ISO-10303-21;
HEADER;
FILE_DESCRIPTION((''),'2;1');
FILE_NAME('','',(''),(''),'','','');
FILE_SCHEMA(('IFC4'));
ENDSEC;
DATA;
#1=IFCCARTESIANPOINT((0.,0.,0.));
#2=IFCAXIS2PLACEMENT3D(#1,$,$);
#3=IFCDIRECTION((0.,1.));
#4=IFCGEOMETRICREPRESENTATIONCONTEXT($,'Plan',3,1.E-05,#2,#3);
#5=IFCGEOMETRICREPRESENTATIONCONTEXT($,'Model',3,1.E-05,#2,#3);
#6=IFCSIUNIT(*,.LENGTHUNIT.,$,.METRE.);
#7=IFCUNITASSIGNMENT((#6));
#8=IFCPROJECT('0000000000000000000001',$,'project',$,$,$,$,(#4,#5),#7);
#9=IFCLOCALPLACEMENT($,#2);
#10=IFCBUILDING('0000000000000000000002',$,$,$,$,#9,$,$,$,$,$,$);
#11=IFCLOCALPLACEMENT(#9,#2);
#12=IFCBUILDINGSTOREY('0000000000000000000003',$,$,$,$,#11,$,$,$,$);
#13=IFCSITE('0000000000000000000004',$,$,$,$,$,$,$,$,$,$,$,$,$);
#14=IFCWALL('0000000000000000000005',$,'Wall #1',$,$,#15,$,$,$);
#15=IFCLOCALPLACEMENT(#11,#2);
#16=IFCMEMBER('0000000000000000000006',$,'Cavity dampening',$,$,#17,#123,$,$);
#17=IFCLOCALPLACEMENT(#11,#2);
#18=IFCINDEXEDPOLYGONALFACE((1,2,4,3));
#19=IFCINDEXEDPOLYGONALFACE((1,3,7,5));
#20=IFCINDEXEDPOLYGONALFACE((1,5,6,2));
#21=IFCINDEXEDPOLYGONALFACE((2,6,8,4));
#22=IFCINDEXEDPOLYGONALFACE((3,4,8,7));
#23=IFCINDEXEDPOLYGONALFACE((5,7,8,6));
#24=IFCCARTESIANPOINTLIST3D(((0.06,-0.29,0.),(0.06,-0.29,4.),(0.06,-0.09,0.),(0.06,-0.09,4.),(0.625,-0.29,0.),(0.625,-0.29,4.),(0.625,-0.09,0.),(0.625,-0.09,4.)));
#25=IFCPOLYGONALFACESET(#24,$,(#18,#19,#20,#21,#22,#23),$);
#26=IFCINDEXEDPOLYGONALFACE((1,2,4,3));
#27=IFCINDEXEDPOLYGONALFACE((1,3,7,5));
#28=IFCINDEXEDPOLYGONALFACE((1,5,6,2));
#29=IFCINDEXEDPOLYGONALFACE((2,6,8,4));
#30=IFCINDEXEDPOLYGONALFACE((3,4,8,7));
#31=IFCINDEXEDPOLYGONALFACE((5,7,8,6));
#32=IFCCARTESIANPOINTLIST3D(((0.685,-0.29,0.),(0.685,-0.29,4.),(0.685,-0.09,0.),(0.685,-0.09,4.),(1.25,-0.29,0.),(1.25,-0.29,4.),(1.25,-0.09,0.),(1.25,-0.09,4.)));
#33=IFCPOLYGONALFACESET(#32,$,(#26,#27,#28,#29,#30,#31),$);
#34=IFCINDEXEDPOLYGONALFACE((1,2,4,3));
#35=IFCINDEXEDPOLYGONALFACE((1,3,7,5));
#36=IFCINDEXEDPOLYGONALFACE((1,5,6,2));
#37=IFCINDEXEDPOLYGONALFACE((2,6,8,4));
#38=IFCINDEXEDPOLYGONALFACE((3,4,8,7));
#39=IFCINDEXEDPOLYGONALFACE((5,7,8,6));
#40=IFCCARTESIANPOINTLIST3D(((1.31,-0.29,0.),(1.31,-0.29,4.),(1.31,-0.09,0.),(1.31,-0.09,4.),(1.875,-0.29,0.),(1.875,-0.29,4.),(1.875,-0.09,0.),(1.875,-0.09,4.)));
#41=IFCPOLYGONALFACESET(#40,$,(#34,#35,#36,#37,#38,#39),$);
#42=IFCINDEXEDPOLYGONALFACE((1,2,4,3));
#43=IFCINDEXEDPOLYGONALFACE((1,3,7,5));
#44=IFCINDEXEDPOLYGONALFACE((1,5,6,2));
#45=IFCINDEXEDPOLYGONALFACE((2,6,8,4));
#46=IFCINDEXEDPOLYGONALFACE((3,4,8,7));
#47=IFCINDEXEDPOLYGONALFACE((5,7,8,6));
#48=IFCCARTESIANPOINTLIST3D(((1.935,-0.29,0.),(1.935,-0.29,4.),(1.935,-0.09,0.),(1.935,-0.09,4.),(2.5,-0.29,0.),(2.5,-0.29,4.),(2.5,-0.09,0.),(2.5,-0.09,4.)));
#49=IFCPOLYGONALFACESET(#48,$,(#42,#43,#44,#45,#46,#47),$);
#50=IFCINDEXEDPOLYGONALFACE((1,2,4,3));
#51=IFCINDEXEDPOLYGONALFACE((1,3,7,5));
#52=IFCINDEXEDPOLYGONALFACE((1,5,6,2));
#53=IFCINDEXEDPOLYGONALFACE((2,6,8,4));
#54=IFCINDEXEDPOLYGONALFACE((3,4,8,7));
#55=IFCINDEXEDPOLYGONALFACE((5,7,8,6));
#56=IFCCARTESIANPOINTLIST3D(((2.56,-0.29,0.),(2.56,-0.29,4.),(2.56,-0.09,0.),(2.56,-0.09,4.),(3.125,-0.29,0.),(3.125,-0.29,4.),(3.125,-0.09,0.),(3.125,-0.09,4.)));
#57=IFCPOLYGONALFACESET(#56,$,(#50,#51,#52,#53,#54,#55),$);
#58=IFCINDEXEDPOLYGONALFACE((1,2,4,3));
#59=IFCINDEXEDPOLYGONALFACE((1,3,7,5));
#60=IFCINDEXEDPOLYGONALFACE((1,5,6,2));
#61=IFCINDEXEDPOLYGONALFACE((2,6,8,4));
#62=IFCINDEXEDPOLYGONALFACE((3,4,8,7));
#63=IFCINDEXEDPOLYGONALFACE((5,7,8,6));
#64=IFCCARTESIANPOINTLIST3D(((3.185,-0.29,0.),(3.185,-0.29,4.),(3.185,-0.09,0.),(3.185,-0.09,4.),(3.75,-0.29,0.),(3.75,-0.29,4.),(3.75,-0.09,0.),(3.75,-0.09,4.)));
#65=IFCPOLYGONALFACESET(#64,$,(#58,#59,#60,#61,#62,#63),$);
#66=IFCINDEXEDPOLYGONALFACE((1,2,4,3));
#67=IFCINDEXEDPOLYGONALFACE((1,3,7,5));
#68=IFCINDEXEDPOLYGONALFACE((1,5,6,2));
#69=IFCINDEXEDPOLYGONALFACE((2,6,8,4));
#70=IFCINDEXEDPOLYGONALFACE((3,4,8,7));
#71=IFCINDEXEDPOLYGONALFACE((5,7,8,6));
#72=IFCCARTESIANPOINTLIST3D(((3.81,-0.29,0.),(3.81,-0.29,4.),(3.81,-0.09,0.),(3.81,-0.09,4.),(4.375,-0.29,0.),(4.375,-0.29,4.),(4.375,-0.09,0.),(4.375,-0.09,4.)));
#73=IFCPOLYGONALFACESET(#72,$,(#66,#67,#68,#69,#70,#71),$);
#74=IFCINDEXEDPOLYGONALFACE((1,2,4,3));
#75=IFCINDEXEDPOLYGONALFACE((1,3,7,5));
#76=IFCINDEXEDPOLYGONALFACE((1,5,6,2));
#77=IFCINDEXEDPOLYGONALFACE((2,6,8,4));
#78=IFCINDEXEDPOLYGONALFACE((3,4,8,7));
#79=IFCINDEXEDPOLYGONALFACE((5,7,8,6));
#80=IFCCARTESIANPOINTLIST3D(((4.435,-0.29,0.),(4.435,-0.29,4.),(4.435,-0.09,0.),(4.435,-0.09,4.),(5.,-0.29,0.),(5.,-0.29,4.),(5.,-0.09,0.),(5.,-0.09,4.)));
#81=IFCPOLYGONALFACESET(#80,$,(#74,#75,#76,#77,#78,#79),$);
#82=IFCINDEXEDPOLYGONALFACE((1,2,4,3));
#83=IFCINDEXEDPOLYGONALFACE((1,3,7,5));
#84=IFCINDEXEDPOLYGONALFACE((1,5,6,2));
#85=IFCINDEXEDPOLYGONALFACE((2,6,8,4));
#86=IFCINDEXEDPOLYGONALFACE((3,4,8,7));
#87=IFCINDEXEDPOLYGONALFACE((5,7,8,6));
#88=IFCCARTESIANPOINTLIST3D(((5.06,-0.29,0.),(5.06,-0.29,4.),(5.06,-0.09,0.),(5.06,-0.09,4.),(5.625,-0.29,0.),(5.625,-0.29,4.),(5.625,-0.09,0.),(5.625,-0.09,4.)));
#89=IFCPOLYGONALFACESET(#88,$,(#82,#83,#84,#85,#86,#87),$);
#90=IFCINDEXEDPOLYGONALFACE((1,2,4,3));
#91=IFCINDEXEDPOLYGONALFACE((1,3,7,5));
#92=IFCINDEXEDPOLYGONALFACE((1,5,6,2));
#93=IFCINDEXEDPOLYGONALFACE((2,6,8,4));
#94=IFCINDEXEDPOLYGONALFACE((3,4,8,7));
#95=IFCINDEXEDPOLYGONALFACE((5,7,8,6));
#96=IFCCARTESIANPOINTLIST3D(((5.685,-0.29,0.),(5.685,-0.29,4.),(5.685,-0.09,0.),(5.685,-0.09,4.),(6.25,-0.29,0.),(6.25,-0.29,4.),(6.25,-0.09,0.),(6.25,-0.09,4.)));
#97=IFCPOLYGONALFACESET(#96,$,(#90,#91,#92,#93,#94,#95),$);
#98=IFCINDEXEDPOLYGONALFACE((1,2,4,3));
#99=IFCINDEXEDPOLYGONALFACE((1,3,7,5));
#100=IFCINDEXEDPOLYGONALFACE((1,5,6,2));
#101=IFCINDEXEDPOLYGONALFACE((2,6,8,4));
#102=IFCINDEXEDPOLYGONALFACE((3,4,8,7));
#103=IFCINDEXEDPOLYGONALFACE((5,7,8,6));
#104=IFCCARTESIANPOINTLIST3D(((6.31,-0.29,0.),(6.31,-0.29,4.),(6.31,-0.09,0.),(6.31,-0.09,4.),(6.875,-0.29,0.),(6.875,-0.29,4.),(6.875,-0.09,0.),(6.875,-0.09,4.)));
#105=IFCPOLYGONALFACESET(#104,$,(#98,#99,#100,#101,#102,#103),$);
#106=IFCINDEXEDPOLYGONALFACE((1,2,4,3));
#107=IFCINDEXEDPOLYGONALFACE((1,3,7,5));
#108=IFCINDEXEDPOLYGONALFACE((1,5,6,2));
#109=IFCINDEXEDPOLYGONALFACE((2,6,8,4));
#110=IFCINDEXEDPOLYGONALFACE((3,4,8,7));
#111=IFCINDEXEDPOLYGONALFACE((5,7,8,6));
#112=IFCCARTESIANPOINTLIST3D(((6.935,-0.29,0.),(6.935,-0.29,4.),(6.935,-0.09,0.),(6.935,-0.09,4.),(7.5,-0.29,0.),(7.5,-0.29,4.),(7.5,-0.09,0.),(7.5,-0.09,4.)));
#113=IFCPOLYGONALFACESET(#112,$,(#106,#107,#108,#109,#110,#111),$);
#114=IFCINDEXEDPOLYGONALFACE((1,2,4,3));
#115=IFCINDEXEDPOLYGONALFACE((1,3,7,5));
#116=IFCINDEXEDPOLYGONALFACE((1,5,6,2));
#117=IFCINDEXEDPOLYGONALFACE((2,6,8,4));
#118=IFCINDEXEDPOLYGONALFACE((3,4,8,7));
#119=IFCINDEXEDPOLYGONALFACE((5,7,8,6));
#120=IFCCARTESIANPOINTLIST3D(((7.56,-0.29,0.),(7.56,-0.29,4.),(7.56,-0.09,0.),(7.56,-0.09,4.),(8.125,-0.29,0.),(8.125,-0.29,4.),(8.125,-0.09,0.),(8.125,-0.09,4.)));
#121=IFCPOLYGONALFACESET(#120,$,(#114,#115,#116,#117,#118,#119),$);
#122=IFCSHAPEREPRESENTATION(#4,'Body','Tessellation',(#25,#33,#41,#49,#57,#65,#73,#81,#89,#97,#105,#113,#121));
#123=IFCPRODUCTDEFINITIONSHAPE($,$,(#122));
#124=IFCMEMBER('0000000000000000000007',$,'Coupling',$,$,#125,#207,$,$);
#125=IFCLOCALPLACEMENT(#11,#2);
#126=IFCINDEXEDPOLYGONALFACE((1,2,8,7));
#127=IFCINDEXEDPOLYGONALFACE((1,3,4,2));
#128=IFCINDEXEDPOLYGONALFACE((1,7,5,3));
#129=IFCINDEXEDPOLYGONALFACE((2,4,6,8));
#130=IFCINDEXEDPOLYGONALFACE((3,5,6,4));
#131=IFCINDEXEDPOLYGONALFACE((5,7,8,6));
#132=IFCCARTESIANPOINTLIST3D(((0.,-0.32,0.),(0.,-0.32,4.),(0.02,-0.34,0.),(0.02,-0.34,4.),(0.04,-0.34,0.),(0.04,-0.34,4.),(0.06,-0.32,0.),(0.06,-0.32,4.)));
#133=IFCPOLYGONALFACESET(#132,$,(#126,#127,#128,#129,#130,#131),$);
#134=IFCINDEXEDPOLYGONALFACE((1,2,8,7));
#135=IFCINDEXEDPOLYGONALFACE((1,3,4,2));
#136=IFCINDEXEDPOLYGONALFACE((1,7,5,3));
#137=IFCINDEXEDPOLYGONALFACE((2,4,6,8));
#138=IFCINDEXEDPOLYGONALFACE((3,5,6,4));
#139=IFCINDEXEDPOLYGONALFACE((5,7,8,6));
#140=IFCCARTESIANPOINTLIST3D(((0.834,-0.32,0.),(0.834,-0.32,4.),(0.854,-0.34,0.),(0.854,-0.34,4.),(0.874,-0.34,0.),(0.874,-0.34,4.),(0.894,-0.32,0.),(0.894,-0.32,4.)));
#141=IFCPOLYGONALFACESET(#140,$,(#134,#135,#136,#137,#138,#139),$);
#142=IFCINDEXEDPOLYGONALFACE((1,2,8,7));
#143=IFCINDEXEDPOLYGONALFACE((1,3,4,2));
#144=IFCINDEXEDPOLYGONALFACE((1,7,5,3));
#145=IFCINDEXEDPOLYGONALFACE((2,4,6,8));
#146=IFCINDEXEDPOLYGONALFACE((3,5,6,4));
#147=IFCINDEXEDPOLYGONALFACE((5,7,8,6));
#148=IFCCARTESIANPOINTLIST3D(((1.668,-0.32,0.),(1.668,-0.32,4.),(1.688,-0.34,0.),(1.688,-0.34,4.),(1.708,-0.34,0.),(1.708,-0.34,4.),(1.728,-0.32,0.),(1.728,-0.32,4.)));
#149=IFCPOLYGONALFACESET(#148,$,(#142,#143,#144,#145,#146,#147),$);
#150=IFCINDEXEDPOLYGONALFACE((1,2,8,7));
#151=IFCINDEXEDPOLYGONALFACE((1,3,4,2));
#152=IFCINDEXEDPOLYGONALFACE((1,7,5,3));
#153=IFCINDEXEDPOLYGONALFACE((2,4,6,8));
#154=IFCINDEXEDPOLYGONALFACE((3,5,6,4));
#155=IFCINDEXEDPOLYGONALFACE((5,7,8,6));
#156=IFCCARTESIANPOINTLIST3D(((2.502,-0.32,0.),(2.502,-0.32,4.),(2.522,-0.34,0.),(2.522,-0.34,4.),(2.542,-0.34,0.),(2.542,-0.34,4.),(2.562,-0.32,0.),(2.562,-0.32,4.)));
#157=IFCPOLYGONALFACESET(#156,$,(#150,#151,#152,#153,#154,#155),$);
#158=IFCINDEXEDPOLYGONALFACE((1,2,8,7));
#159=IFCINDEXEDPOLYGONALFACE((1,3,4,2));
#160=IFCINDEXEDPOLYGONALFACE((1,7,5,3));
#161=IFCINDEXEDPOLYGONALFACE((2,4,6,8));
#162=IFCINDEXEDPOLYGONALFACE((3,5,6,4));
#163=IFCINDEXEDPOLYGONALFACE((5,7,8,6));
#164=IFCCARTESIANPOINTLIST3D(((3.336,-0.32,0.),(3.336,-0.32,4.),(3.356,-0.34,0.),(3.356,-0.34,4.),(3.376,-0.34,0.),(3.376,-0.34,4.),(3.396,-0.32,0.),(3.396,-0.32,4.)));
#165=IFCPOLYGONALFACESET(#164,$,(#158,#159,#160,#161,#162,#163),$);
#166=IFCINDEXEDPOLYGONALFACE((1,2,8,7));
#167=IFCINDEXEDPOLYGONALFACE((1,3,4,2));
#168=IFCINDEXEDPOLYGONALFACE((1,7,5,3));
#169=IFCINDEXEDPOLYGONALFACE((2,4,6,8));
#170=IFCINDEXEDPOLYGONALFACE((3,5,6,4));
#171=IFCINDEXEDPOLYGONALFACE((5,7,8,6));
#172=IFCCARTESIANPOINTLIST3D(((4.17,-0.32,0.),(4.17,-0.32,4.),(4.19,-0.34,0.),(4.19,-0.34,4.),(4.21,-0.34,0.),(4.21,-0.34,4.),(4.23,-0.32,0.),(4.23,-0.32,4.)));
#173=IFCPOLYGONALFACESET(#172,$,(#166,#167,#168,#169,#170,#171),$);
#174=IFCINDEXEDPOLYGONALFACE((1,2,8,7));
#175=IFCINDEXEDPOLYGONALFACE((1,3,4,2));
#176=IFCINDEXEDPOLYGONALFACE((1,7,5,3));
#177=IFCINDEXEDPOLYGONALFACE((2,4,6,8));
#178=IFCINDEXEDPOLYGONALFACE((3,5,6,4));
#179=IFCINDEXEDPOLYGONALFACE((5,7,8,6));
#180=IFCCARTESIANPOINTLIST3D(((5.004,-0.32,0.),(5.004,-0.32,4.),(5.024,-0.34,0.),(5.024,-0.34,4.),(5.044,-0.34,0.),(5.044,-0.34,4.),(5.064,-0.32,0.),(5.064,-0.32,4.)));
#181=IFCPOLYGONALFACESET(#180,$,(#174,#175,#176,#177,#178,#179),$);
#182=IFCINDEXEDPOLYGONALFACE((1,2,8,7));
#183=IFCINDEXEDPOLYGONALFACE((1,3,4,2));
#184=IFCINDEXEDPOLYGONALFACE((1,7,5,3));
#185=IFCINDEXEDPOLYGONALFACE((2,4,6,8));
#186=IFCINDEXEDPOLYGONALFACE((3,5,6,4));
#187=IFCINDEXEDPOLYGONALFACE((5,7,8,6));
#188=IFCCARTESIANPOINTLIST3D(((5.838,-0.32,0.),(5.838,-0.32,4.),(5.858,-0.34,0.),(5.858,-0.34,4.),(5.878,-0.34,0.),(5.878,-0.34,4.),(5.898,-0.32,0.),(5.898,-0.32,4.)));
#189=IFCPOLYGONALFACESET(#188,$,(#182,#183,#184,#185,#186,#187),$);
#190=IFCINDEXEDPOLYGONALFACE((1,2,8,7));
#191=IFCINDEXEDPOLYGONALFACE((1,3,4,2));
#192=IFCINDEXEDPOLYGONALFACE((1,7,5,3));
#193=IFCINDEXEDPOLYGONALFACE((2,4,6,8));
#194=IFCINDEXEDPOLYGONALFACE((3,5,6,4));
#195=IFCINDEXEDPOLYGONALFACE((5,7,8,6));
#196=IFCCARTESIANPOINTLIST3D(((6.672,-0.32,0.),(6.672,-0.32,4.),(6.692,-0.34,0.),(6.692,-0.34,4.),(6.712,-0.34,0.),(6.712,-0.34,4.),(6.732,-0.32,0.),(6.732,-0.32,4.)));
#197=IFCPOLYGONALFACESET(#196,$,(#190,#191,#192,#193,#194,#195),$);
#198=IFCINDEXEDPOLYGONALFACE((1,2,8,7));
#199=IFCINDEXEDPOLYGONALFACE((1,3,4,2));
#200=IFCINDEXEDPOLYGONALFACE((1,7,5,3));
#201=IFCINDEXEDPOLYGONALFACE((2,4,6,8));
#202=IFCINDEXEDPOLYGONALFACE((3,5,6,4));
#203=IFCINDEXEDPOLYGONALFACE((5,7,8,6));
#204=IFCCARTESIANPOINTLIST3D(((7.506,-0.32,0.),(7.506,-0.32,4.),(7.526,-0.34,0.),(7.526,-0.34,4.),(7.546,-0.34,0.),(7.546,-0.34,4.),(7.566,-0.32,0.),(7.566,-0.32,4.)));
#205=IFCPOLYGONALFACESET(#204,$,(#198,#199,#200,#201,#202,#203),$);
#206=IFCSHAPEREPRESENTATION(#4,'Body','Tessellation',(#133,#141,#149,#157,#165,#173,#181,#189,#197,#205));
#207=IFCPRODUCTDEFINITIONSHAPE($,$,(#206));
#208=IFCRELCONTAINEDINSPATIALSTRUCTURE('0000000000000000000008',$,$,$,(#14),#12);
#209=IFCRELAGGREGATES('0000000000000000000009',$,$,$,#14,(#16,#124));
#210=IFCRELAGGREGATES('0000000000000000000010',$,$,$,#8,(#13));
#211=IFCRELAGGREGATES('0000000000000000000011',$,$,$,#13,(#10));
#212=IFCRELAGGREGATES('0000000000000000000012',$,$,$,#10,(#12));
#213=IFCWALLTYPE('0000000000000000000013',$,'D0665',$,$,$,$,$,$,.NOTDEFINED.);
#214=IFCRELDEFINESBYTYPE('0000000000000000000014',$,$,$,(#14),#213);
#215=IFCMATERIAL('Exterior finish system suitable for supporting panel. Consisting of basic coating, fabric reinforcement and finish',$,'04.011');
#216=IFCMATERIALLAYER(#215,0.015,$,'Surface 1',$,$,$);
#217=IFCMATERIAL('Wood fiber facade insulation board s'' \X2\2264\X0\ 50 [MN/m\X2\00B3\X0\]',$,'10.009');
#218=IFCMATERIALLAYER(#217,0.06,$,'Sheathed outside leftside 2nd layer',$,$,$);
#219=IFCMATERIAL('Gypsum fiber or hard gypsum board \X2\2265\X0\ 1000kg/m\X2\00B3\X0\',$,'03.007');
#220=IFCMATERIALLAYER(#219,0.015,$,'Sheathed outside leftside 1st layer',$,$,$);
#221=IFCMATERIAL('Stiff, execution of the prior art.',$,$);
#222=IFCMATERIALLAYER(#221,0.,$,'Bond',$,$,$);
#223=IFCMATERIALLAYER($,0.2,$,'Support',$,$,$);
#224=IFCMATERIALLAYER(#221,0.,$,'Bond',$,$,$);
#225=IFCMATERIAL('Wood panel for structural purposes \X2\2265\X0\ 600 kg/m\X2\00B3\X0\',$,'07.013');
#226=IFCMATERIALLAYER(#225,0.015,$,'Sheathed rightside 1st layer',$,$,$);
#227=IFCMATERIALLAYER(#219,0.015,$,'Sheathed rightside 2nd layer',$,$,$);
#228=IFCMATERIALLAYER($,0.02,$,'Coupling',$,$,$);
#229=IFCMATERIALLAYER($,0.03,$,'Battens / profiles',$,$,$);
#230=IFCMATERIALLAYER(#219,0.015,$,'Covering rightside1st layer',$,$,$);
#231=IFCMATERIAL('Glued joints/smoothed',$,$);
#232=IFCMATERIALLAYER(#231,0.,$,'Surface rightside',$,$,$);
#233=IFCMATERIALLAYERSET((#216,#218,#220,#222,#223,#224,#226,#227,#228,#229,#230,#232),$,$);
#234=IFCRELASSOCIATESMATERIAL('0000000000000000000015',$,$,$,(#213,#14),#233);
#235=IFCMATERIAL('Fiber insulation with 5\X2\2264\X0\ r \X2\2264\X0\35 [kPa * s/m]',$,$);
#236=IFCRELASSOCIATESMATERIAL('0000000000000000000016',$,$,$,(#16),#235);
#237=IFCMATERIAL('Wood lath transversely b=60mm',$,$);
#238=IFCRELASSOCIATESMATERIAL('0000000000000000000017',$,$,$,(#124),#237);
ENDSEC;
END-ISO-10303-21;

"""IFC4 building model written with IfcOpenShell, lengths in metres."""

from ifc_helpers import new_model, si_unit, direction, frame, frame_2d, origin, place, context, project, spatial, polyline, rectangle, outline, extrude, material, layer, layer_set, type_object, element, aggregate, save


model = new_model("IFC4")

# Units and contexts
plan_context = context("Plan", 3, precision=1e-05, world=origin(), true_north=direction((0.0, 1.0)))
model_context = context("Model", 3, precision=1e-05, world=origin(), true_north=direction((0.0, 1.0)))
ifc_project = project(units=[si_unit("LENGTHUNIT", "METRE")], contexts=[plan_context, model_context])

# Site, building, storey
site = spatial("IfcSite", under=ifc_project)
building_placement = place(None, origin())
building = spatial("IfcBuilding", under=site, at=building_placement)
storey_placement = place(building_placement, origin())
storey = spatial("IfcBuildingStorey", under=building, at=storey_placement)

# Wall, members
ifc_material_1 = material(Name="Exterior finish system suitable for supporting panel. Consisting of basic coating, fabric reinforcement and finish", Category="04.011")
ifc_layer_1 = layer(ifc_material_1, 0.015, Name="Surface 1")
ifc_material_2 = material(Name="Wood fiber facade insulation board s' ≤ 50 [MN/m³]", Category="10.009")
ifc_layer_2 = layer(ifc_material_2, 0.06, Name="Sheathed outside leftside 2nd layer")
ifc_material_3 = material(Name="Gypsum fiber or hard gypsum board ≥ 1000kg/m³", Category="03.007")
ifc_layer_3 = layer(ifc_material_3, 0.015, Name="Sheathed outside leftside 1st layer")
ifc_material_4 = material(Name="Stiff, execution of the prior art.")
ifc_layer_4 = layer(ifc_material_4, 0.0, Name="Bond")
ifc_layer_5 = layer(None, 0.2, Name="Support")
ifc_layer_6 = layer(ifc_material_4, 0.0, Name="Bond")
ifc_material_5 = material(Name="Wood panel for structural purposes ≥ 600 kg/m³", Category="07.013")
ifc_layer_7 = layer(ifc_material_5, 0.015, Name="Sheathed rightside 1st layer")
ifc_layer_8 = layer(ifc_material_3, 0.015, Name="Sheathed rightside 2nd layer")
ifc_layer_9 = layer(None, 0.02, Name="Coupling")
ifc_layer_10 = layer(None, 0.03, Name="Battens / profiles")
ifc_layer_11 = layer(ifc_material_3, 0.015, Name="Covering rightside1st layer")
ifc_material_6 = material(Name="Glued joints/smoothed")
ifc_layer_12 = layer(ifc_material_6, 0.0, Name="Surface rightside")
ifc_layer_set = layer_set([ifc_layer_1, ifc_layer_2, ifc_layer_3, ifc_layer_4, ifc_layer_5, ifc_layer_6, ifc_layer_7, ifc_layer_8, ifc_layer_9, ifc_layer_10, ifc_layer_11, ifc_layer_12])
wall_type = type_object("IfcWallType", Name="D0665", PredefinedType="NOTDEFINED", material=ifc_layer_set)
wall_placement = place(None, frame((0.0, 0.0, 0.0), z_axis=(0.0, -1.0, 0.0), x_axis=(1.0, 0.0, 0.0)))
wall = element("IfcWall", 1, at=wall_placement, inside=storey, type_object=wall_type, material=ifc_layer_set, Name="Wall #1")
ifc_material_7 = material(Name="Fiber insulation with 5≤ r ≤35 [kPa * s/m]")
member_1_placement = place(wall_placement, origin())
member_1 = element("IfcMember", 2, at=member_1_placement, material=ifc_material_7, Name="Cavity dampening", context=plan_context, shape_type="SweptSolid", body=[
    extrude(rectangle(XDim=0.565, YDim=0.2, at=frame_2d((0.2825, 0.1), x_axis=(1.0, 0.0))), frame((0.06, 4.0, 0.09), z_axis=(0.0, -1.0, 0.0), x_axis=(1.0, 0.0, 0.0)), (0.0, 0.0, 1.0), 4.0),
    extrude(rectangle(XDim=0.565, YDim=0.2, at=frame_2d((0.2825, 0.1), x_axis=(1.0, 0.0))), frame((0.685, 4.0, 0.09), z_axis=(0.0, -1.0, 0.0), x_axis=(1.0, 0.0, 0.0)), (0.0, 0.0, 1.0), 4.0),
    extrude(rectangle(XDim=0.565, YDim=0.2, at=frame_2d((0.2825, 0.1), x_axis=(1.0, 0.0))), frame((1.31, 4.0, 0.09), z_axis=(0.0, -1.0, 0.0), x_axis=(1.0, 0.0, 0.0)), (0.0, 0.0, 1.0), 4.0),
    extrude(rectangle(XDim=0.565, YDim=0.2, at=frame_2d((0.2825, 0.1), x_axis=(1.0, 0.0))), frame((1.935, 4.0, 0.09), z_axis=(0.0, -1.0, 0.0), x_axis=(1.0, 0.0, 0.0)), (0.0, 0.0, 1.0), 4.0),
    extrude(rectangle(XDim=0.565, YDim=0.2, at=frame_2d((0.2825, 0.1), x_axis=(1.0, 0.0))), frame((2.56, 4.0, 0.09), z_axis=(0.0, -1.0, 0.0), x_axis=(1.0, 0.0, 0.0)), (0.0, 0.0, 1.0), 4.0),
    extrude(rectangle(XDim=0.565, YDim=0.2, at=frame_2d((0.2825, 0.1), x_axis=(1.0, 0.0))), frame((3.185, 4.0, 0.09), z_axis=(0.0, -1.0, 0.0), x_axis=(1.0, 0.0, 0.0)), (0.0, 0.0, 1.0), 4.0),
    extrude(rectangle(XDim=0.565, YDim=0.2, at=frame_2d((0.2825, 0.1), x_axis=(1.0, 0.0))), frame((3.81, 4.0, 0.09), z_axis=(0.0, -1.0, 0.0), x_axis=(1.0, 0.0, 0.0)), (0.0, 0.0, 1.0), 4.0),
    extrude(rectangle(XDim=0.565, YDim=0.2, at=frame_2d((0.2825, 0.1), x_axis=(1.0, 0.0))), frame((4.435, 4.0, 0.09), z_axis=(0.0, -1.0, 0.0), x_axis=(1.0, 0.0, 0.0)), (0.0, 0.0, 1.0), 4.0),
    extrude(rectangle(XDim=0.565, YDim=0.2, at=frame_2d((0.2825, 0.1), x_axis=(1.0, 0.0))), frame((5.06, 4.0, 0.09), z_axis=(0.0, -1.0, 0.0), x_axis=(1.0, 0.0, 0.0)), (0.0, 0.0, 1.0), 4.0),
    extrude(rectangle(XDim=0.565, YDim=0.2, at=frame_2d((0.2825, 0.1), x_axis=(1.0, 0.0))), frame((5.685, 4.0, 0.09), z_axis=(0.0, -1.0, 0.0), x_axis=(1.0, 0.0, 0.0)), (0.0, 0.0, 1.0), 4.0),
    extrude(rectangle(XDim=0.565, YDim=0.2, at=frame_2d((0.2825, 0.1), x_axis=(1.0, 0.0))), frame((6.31, 4.0, 0.09), z_axis=(0.0, -1.0, 0.0), x_axis=(1.0, 0.0, 0.0)), (0.0, 0.0, 1.0), 4.0),
    extrude(rectangle(XDim=0.565, YDim=0.2, at=frame_2d((0.2825, 0.1), x_axis=(1.0, 0.0))), frame((6.935, 4.0, 0.09), z_axis=(0.0, -1.0, 0.0), x_axis=(1.0, 0.0, 0.0)), (0.0, 0.0, 1.0), 4.0),
    extrude(rectangle(XDim=0.565, YDim=0.2, at=frame_2d((0.2825, 0.1), x_axis=(1.0, 0.0))), frame((7.56, 4.0, 0.09), z_axis=(0.0, -1.0, 0.0), x_axis=(1.0, 0.0, 0.0)), (0.0, 0.0, 1.0), 4.0),
])
ifc_material_8 = material(Name="Wood lath transversely b=60mm")
member_2_placement = place(wall_placement, origin())
member_2 = element("IfcMember", 3, at=member_2_placement, material=ifc_material_8, Name="Coupling", context=plan_context, shape_type="SweptSolid", body=[
    extrude(outline(polyline([(0.0, 0.0), (0.06, 0.0), (0.04, 0.02), (0.02, 0.02), (0.0, 0.0)])), frame((0.0, 4.0, 0.32), z_axis=(0.0, -1.0, 0.0), x_axis=(1.0, 0.0, 0.0)), (0.0, 0.0, 1.0), 4.0),
    extrude(outline(polyline([(0.0, 0.0), (0.06, 0.0), (0.04, 0.02), (0.02, 0.02), (0.0, 0.0)])), frame((0.834, 4.0, 0.32), z_axis=(0.0, -1.0, 0.0), x_axis=(1.0, 0.0, 0.0)), (0.0, 0.0, 1.0), 4.0),
    extrude(outline(polyline([(0.0, 0.0), (0.06, 0.0), (0.04, 0.02), (0.02, 0.02), (0.0, 0.0)])), frame((1.668, 4.0, 0.32), z_axis=(0.0, -1.0, 0.0), x_axis=(1.0, 0.0, 0.0)), (0.0, 0.0, 1.0), 4.0),
    extrude(outline(polyline([(0.0, 0.0), (0.06, 0.0), (0.04, 0.02), (0.02, 0.02), (0.0, 0.0)])), frame((2.502, 4.0, 0.32), z_axis=(0.0, -1.0, 0.0), x_axis=(1.0, 0.0, 0.0)), (0.0, 0.0, 1.0), 4.0),
    extrude(outline(polyline([(0.0, 0.0), (0.06, 0.0), (0.04, 0.02), (0.02, 0.02), (0.0, 0.0)])), frame((3.336, 4.0, 0.32), z_axis=(0.0, -1.0, 0.0), x_axis=(1.0, 0.0, 0.0)), (0.0, 0.0, 1.0), 4.0),
    extrude(outline(polyline([(0.0, 0.0), (0.06, 0.0), (0.04, 0.02), (0.02, 0.02), (0.0, 0.0)])), frame((4.17, 4.0, 0.32), z_axis=(0.0, -1.0, 0.0), x_axis=(1.0, 0.0, 0.0)), (0.0, 0.0, 1.0), 4.0),
    extrude(outline(polyline([(0.0, 0.0), (0.06, 0.0), (0.04, 0.02), (0.02, 0.02), (0.0, 0.0)])), frame((5.004, 4.0, 0.32), z_axis=(0.0, -1.0, 0.0), x_axis=(1.0, 0.0, 0.0)), (0.0, 0.0, 1.0), 4.0),
    extrude(outline(polyline([(0.0, 0.0), (0.06, 0.0), (0.04, 0.02), (0.02, 0.02), (0.0, 0.0)])), frame((5.838, 4.0, 0.32), z_axis=(0.0, -1.0, 0.0), x_axis=(1.0, 0.0, 0.0)), (0.0, 0.0, 1.0), 4.0),
    extrude(outline(polyline([(0.0, 0.0), (0.06, 0.0), (0.04, 0.02), (0.02, 0.02), (0.0, 0.0)])), frame((6.672, 4.0, 0.32), z_axis=(0.0, -1.0, 0.0), x_axis=(1.0, 0.0, 0.0)), (0.0, 0.0, 1.0), 4.0),
    extrude(outline(polyline([(0.0, 0.0), (0.06, 0.0), (0.04, 0.02), (0.02, 0.02), (0.0, 0.0)])), frame((7.506, 4.0, 0.32), z_axis=(0.0, -1.0, 0.0), x_axis=(1.0, 0.0, 0.0)), (0.0, 0.0, 1.0), 4.0),
])
aggregate(wall, [member_1, member_2])

save(model, "model.ifc")
